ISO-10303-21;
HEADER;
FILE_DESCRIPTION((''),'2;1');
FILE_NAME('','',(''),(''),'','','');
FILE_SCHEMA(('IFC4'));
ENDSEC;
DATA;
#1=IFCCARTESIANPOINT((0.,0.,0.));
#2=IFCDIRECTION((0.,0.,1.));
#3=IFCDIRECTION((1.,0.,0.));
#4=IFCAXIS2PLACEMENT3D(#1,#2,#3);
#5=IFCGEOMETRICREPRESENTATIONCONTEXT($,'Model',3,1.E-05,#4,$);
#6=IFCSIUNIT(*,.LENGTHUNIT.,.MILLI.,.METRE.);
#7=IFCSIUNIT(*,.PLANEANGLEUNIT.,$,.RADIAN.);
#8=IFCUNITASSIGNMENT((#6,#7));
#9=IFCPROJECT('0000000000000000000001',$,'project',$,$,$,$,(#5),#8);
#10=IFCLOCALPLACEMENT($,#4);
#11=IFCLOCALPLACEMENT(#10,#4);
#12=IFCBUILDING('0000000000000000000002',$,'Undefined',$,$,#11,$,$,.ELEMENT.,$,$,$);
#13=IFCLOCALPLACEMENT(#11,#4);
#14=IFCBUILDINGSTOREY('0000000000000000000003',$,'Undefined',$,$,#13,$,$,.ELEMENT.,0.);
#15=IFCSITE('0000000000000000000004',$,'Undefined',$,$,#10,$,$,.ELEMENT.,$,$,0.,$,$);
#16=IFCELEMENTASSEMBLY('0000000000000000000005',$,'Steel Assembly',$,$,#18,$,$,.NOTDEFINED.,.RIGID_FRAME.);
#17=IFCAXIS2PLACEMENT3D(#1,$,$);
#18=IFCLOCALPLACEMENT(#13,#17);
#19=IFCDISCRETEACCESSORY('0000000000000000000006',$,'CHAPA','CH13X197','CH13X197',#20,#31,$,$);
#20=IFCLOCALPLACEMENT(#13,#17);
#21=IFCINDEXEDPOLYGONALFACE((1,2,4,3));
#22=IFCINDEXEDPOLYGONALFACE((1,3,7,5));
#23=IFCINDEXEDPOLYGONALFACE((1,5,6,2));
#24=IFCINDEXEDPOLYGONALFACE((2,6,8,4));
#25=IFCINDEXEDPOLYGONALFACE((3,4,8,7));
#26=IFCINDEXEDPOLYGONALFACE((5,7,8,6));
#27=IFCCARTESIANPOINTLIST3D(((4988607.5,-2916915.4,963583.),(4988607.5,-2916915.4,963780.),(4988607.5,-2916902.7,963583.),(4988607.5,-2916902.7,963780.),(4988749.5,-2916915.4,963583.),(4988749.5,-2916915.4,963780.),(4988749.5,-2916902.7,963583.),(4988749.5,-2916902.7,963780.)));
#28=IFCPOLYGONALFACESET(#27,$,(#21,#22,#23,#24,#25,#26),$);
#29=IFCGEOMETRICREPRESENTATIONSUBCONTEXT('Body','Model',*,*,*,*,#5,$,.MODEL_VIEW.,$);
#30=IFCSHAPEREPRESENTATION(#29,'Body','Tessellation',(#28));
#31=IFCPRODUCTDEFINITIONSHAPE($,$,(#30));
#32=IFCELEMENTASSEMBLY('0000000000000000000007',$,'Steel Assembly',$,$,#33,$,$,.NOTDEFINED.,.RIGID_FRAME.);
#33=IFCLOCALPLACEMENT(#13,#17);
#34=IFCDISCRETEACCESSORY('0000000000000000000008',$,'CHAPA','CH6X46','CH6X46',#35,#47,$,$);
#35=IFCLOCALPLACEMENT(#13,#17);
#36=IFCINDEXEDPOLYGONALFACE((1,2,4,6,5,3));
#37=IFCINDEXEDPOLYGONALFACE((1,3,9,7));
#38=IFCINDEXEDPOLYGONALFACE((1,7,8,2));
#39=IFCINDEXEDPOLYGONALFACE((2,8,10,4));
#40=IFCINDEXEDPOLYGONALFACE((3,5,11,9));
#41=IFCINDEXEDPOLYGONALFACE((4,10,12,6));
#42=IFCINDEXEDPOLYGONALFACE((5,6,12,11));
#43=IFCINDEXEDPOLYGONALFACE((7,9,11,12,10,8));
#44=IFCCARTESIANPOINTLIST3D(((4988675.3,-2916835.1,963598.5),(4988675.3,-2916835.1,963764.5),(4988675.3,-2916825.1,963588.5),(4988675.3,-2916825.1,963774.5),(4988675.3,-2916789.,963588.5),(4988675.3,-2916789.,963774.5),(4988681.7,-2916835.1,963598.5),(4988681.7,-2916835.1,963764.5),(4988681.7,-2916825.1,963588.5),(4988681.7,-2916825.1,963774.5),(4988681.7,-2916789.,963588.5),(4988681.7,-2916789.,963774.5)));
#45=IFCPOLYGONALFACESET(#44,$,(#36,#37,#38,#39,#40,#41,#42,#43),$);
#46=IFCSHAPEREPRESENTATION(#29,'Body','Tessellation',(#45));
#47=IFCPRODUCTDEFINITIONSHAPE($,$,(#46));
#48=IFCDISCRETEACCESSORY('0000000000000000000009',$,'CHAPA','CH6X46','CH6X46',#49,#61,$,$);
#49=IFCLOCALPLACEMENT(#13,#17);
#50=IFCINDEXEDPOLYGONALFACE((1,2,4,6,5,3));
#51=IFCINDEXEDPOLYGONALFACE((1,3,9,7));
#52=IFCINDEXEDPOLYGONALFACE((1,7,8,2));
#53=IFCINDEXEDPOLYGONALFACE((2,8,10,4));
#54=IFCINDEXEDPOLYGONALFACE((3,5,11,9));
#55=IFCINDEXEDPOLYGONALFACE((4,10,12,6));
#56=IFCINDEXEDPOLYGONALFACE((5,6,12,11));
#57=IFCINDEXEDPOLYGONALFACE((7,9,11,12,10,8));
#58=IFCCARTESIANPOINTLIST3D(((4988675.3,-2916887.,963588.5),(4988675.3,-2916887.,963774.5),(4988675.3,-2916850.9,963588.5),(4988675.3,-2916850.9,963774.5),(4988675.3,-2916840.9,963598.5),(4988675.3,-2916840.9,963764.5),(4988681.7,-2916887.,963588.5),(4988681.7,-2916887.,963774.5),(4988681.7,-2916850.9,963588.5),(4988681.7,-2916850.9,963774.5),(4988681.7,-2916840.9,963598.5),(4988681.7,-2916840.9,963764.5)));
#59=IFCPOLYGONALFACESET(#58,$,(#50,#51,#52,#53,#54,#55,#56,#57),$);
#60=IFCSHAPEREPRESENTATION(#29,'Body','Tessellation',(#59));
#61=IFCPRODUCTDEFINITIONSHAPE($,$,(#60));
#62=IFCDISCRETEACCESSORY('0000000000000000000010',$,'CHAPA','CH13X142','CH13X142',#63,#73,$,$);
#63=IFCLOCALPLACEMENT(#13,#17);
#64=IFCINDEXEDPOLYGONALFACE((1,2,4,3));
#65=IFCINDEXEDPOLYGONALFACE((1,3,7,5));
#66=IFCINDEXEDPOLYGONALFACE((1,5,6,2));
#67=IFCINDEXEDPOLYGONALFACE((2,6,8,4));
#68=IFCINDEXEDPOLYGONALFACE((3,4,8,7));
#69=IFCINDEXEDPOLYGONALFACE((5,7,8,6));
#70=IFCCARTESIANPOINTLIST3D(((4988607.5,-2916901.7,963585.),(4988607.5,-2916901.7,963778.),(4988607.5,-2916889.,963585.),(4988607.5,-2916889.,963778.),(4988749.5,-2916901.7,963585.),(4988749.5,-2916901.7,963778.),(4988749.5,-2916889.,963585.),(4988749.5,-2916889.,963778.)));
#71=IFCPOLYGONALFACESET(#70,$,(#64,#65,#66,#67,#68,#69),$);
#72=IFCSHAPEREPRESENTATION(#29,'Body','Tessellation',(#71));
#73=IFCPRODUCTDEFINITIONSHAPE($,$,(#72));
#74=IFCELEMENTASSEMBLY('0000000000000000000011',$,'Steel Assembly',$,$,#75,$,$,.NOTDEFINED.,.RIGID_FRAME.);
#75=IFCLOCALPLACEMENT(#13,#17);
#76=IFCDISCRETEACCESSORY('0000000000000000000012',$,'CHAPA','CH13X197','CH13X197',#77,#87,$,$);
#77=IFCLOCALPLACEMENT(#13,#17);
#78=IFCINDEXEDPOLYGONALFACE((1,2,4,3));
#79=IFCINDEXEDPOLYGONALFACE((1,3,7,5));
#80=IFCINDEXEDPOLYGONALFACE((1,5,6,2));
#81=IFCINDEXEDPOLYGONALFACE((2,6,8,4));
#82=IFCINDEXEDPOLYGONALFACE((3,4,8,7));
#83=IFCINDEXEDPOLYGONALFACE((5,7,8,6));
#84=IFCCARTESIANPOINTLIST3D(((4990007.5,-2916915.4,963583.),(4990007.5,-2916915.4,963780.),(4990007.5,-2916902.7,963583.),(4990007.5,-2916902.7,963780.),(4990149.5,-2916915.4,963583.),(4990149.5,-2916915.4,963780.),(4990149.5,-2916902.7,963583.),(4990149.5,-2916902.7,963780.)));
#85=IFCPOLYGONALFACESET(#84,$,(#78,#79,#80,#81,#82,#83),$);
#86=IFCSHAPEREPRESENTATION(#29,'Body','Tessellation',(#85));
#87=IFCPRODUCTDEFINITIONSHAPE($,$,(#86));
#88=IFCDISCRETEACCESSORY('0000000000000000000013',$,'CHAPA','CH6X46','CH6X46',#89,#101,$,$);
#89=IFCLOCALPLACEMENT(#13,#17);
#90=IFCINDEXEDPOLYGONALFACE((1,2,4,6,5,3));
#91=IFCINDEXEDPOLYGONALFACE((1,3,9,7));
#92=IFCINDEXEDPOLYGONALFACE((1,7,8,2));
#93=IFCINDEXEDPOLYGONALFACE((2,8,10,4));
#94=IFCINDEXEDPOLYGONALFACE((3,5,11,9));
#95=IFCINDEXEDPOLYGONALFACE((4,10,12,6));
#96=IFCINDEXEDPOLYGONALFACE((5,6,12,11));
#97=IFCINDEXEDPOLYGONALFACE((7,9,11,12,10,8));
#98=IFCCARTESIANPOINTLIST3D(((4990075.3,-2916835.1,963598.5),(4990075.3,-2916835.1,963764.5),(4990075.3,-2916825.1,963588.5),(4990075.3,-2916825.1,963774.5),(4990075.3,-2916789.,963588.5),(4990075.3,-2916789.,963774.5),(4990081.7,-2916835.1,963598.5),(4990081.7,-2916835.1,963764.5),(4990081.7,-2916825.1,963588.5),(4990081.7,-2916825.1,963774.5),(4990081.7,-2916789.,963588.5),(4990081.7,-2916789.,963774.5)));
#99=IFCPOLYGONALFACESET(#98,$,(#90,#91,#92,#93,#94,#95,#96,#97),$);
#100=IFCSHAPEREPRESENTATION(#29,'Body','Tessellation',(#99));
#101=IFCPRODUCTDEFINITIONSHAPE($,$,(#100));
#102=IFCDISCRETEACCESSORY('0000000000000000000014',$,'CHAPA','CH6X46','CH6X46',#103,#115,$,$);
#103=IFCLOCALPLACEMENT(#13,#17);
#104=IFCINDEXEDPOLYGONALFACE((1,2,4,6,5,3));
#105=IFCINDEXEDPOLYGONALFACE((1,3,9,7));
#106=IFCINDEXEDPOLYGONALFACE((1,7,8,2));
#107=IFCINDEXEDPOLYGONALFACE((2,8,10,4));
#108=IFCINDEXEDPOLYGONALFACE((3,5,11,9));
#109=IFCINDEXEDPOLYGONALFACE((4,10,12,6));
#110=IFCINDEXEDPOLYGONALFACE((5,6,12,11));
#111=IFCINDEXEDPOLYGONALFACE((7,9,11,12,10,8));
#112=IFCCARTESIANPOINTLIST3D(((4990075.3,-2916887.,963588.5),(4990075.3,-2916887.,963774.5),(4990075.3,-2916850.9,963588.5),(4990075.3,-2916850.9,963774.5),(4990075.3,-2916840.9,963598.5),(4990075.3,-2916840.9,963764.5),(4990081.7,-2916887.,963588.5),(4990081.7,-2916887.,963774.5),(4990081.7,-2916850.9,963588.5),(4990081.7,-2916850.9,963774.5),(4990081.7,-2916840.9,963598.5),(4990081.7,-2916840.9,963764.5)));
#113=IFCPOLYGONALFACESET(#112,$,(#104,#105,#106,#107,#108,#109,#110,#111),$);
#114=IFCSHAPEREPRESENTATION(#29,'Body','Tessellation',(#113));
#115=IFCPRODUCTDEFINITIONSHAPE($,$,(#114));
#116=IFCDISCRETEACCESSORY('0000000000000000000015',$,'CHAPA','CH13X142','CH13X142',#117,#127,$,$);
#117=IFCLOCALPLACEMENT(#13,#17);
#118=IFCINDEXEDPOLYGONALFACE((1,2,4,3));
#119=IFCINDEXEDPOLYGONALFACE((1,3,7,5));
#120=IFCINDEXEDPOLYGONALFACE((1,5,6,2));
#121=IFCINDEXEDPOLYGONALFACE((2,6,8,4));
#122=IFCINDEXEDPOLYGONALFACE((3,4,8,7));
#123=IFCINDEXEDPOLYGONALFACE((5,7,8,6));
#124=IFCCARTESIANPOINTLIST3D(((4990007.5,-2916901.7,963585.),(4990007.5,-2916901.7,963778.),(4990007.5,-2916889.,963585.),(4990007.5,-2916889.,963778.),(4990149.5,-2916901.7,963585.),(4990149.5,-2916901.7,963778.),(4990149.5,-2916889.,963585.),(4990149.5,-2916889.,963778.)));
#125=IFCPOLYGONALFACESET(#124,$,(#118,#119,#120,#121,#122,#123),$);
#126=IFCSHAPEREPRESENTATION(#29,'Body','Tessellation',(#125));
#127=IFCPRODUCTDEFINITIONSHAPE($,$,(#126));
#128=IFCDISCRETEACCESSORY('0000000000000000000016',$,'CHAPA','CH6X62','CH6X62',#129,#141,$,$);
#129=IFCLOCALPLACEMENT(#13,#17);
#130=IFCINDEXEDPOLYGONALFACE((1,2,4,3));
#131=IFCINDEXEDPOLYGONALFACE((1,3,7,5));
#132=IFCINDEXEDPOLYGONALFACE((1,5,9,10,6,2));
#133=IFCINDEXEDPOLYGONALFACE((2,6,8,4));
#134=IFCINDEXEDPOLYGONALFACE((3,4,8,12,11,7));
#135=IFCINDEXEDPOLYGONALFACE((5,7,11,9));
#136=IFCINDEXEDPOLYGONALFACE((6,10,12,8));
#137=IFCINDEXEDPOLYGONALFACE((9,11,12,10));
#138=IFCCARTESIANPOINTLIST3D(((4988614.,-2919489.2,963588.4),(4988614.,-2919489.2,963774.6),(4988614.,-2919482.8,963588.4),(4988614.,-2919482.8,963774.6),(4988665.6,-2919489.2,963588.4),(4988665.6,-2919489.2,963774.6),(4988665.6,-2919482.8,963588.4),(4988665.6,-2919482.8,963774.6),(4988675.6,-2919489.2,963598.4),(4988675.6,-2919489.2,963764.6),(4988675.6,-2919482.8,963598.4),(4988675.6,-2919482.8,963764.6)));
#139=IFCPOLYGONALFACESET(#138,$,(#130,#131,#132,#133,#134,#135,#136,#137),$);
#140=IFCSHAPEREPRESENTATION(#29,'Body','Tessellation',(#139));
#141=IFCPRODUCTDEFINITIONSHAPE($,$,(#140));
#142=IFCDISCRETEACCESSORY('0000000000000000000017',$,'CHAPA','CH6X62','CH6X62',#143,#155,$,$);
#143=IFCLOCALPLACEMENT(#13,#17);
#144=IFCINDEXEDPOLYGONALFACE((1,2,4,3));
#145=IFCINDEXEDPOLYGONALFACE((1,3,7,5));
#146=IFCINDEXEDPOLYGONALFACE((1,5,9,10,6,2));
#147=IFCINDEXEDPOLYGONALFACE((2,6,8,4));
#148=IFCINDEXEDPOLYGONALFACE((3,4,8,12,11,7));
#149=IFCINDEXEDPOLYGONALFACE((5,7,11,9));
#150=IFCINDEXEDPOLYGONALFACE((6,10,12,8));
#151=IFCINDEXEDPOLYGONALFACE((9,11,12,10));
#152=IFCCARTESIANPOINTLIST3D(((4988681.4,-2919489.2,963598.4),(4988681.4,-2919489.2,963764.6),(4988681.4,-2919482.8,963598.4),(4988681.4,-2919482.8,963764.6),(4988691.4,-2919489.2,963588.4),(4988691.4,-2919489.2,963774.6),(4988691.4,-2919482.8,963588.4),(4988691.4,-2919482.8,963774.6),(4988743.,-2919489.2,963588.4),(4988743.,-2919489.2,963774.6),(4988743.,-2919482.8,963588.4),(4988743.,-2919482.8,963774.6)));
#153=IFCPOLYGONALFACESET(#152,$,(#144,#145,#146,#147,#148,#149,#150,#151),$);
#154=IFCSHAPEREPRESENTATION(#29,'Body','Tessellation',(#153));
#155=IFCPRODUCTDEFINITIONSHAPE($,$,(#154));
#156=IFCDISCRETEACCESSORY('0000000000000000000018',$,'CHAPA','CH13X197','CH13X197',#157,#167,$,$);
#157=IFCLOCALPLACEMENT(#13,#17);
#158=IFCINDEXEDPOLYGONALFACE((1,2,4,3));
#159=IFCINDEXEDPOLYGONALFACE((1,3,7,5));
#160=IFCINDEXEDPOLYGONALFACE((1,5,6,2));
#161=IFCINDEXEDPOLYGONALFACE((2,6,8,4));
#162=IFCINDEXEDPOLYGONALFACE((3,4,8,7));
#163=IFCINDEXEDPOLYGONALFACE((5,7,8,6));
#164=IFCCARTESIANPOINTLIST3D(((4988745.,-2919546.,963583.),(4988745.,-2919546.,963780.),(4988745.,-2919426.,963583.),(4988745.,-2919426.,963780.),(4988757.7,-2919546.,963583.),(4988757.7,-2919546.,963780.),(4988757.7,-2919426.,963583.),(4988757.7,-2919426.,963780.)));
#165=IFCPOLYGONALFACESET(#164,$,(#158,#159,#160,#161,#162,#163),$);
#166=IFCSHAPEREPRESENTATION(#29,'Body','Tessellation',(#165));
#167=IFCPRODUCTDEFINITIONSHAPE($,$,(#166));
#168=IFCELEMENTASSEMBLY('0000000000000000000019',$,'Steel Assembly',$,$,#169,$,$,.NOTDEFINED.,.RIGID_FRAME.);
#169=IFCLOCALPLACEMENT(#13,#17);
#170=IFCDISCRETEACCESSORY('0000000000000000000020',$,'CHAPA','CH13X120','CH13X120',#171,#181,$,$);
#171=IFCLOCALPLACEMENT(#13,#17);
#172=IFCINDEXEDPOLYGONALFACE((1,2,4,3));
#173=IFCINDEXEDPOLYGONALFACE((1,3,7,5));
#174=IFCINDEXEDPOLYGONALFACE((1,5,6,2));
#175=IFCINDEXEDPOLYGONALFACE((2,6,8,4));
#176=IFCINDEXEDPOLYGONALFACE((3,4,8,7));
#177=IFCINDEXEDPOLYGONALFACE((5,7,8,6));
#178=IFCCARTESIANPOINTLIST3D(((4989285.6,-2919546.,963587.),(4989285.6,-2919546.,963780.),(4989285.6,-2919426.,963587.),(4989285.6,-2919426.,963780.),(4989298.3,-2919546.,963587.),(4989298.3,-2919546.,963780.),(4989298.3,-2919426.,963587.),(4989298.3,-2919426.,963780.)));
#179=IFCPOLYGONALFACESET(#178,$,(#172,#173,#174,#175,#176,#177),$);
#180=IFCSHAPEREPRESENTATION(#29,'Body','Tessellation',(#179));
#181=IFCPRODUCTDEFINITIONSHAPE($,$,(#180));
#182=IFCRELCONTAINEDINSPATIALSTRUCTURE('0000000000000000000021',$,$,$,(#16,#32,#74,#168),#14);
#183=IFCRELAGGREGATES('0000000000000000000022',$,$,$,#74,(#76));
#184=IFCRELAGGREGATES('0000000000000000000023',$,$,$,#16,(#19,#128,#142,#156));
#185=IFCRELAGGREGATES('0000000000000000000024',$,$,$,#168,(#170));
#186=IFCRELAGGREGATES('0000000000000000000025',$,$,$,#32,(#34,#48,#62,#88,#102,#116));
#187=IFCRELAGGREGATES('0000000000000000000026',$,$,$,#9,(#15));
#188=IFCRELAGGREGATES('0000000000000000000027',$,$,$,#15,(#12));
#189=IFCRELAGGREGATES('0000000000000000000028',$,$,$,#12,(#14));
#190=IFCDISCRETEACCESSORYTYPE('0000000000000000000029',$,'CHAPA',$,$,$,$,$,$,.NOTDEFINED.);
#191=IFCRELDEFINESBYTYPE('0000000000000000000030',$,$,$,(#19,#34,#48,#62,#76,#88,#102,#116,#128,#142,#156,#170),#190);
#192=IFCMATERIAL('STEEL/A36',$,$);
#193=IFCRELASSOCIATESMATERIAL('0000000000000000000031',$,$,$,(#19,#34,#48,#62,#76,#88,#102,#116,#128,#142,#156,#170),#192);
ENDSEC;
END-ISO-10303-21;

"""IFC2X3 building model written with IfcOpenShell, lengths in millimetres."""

from ifc_helpers import new_model, si_unit, frame, origin_with_axes, place, context, subcontext, project, spatial, polyline, outline, extrude, material, type_object, element, aggregate, save


model = new_model("IFC2X3")

# Units and contexts
model_context = context("Model", 3, precision=1e-05, world=origin_with_axes())
body_context = subcontext(model_context, "Body", "Model", "MODEL_VIEW")
ifc_project = project(units=[si_unit("LENGTHUNIT", "METRE", prefix="MILLI"), si_unit("PLANEANGLEUNIT", "RADIAN")], contexts=[model_context])

# Site, building, storey
site_placement = place(None, origin_with_axes())
site = spatial("IfcSite", under=ifc_project, at=site_placement, Name="Undefined", CompositionType="ELEMENT", RefElevation=0.0)
building_placement = place(site_placement, origin_with_axes())
building = spatial("IfcBuilding", under=site, at=building_placement, Name="Undefined", CompositionType="ELEMENT")
storey_placement = place(building_placement, origin_with_axes())
storey = spatial("IfcBuildingStorey", under=building, at=storey_placement, Name="Undefined", CompositionType="ELEMENT", Elevation=0.0)

# Element assembly, discrete accessory
assembly_1_placement = place(storey_placement, origin_with_axes())
assembly_1 = element("IfcElementAssembly", 1, at=assembly_1_placement, inside=storey, Name="Steel Assembly", AssemblyPlace="NOTDEFINED", PredefinedType="RIGID_FRAME")
ifc_material_1 = material(Name="STEEL/A36")
discrete_accessory_type_1 = type_object("IfcDiscreteAccessoryType", Name="CHAPA")
discrete_accessory_1_placement = place(assembly_1_placement, frame((4988678.5, -2916909.1, 963780.0), z_axis=(0.0, -1.0, 0.0), x_axis=(0.0, 0.0, -1.0)))
discrete_accessory_1 = element("IfcDiscreteAccessory", 2, at=discrete_accessory_1_placement, type_object=discrete_accessory_type_1, material=ifc_material_1, Name="CHAPA", Description="CH13X197", ObjectType="CH13X197", context=body_context, shape_type="SweptSolid", body=[
    extrude(outline(polyline([(197.0, -71.0), (0.0, -71.0), (0.0, 71.0), (197.0, 71.0), (197.0, -71.0)])), frame((0.0, 0.0, -6.3), z_axis=(0.0, 0.0, 1.0), x_axis=(1.0, 0.0, 0.0)), (0.0, 0.0, 1.0), 12.7),
])

# Element assembly, discrete accessories
assembly_2_placement = place(storey_placement, origin_with_axes())
assembly_2 = element("IfcElementAssembly", 3, at=assembly_2_placement, inside=storey, Name="Steel Assembly", AssemblyPlace="NOTDEFINED", PredefinedType="RIGID_FRAME")
discrete_accessory_2_placement = place(assembly_2_placement, frame((4988678.5, -2916835.1, 963774.5), z_axis=(-1.0, 0.0, 0.0), x_axis=(0.0, 1.0, 0.0)))
discrete_accessory_2 = element("IfcDiscreteAccessory", 4, at=discrete_accessory_2_placement, type_object=discrete_accessory_type_1, material=ifc_material_1, Name="CHAPA", Description="CH6X46", ObjectType="CH6X46", context=body_context, shape_type="SweptSolid", body=[
    extrude(outline(polyline([(0.0, 10.0), (10.0, 0.0), (46.1, 0.0), (46.1, 186.0), (10.0, 186.0), (0.0, 176.0), (0.0, 10.0)])), frame((0.0, 0.0, -3.2), z_axis=(0.0, 0.0, 1.0), x_axis=(1.0, 0.0, 0.0)), (0.0, 0.0, 1.0), 6.4),
])
discrete_accessory_3_placement = place(assembly_2_placement, frame((4988678.5, -2916840.9, 963774.5), z_axis=(1.0, 0.0, 0.0), x_axis=(0.0, -1.0, 0.0)))
discrete_accessory_3 = element("IfcDiscreteAccessory", 5, at=discrete_accessory_3_placement, type_object=discrete_accessory_type_1, material=ifc_material_1, Name="CHAPA", Description="CH6X46", ObjectType="CH6X46", context=body_context, shape_type="SweptSolid", body=[
    extrude(outline(polyline([(0.0, 10.0), (10.0, 0.0), (46.1, 0.0), (46.1, 186.0), (10.0, 186.0), (0.0, 176.0), (0.0, 10.0)])), frame((0.0, 0.0, -3.2), z_axis=(0.0, 0.0, 1.0), x_axis=(1.0, 0.0, 0.0)), (0.0, 0.0, 1.0), 6.4),
])
discrete_accessory_4_placement = place(assembly_2_placement, frame((4988678.5, -2916895.4, 963778.0), z_axis=(0.0, -1.0, 0.0), x_axis=(0.0, 0.0, -1.0)))
discrete_accessory_4 = element("IfcDiscreteAccessory", 6, at=discrete_accessory_4_placement, type_object=discrete_accessory_type_1, material=ifc_material_1, Name="CHAPA", Description="CH13X142", ObjectType="CH13X142", context=body_context, shape_type="SweptSolid", body=[
    extrude(outline(polyline([(193.0, -71.0), (0.0, -71.0), (0.0, 71.0), (193.0, 71.0), (193.0, -71.0)])), frame((0.0, 0.0, -6.3), z_axis=(0.0, 0.0, 1.0), x_axis=(1.0, 0.0, 0.0)), (0.0, 0.0, 1.0), 12.7),
])

# Element assembly, discrete accessory
assembly_3_placement = place(storey_placement, origin_with_axes())
assembly_3 = element("IfcElementAssembly", 7, at=assembly_3_placement, inside=storey, Name="Steel Assembly", AssemblyPlace="NOTDEFINED", PredefinedType="RIGID_FRAME")
discrete_accessory_5_placement = place(assembly_3_placement, frame((4990078.5, -2916909.1, 963780.0), z_axis=(0.0, -1.0, 0.0), x_axis=(0.0, 0.0, -1.0)))
discrete_accessory_5 = element("IfcDiscreteAccessory", 8, at=discrete_accessory_5_placement, type_object=discrete_accessory_type_1, material=ifc_material_1, Name="CHAPA", Description="CH13X197", ObjectType="CH13X197", context=body_context, shape_type="SweptSolid", body=[
    extrude(outline(polyline([(197.0, -71.0), (0.0, -71.0), (0.0, 71.0), (197.0, 71.0), (197.0, -71.0)])), frame((0.0, 0.0, -6.3), z_axis=(0.0, 0.0, 1.0), x_axis=(1.0, 0.0, 0.0)), (0.0, 0.0, 1.0), 12.7),
])
aggregate(assembly_3, [discrete_accessory_5])

# Discrete accessories
discrete_accessory_6_placement = place(assembly_2_placement, frame((4990078.5, -2916835.1, 963774.5), z_axis=(-1.0, 0.0, 0.0), x_axis=(0.0, 1.0, 0.0)))
discrete_accessory_6 = element("IfcDiscreteAccessory", 9, at=discrete_accessory_6_placement, type_object=discrete_accessory_type_1, material=ifc_material_1, Name="CHAPA", Description="CH6X46", ObjectType="CH6X46", context=body_context, shape_type="SweptSolid", body=[
    extrude(outline(polyline([(0.0, 10.0), (10.0, 0.0), (46.1, 0.0), (46.1, 186.0), (10.0, 186.0), (0.0, 176.0), (0.0, 10.0)])), frame((0.0, 0.0, -3.2), z_axis=(0.0, 0.0, 1.0), x_axis=(1.0, 0.0, 0.0)), (0.0, 0.0, 1.0), 6.4),
])
discrete_accessory_7_placement = place(assembly_2_placement, frame((4990078.5, -2916840.9, 963774.5), z_axis=(1.0, 0.0, 0.0), x_axis=(0.0, -1.0, 0.0)))
discrete_accessory_7 = element("IfcDiscreteAccessory", 10, at=discrete_accessory_7_placement, type_object=discrete_accessory_type_1, material=ifc_material_1, Name="CHAPA", Description="CH6X46", ObjectType="CH6X46", context=body_context, shape_type="SweptSolid", body=[
    extrude(outline(polyline([(0.0, 10.0), (10.0, 0.0), (46.1, 0.0), (46.1, 186.0), (10.0, 186.0), (0.0, 176.0), (0.0, 10.0)])), frame((0.0, 0.0, -3.2), z_axis=(0.0, 0.0, 1.0), x_axis=(1.0, 0.0, 0.0)), (0.0, 0.0, 1.0), 6.4),
])
discrete_accessory_8_placement = place(assembly_2_placement, frame((4990078.5, -2916895.4, 963778.0), z_axis=(0.0, -1.0, 0.0), x_axis=(0.0, 0.0, -1.0)))
discrete_accessory_8 = element("IfcDiscreteAccessory", 11, at=discrete_accessory_8_placement, type_object=discrete_accessory_type_1, material=ifc_material_1, Name="CHAPA", Description="CH13X142", ObjectType="CH13X142", context=body_context, shape_type="SweptSolid", body=[
    extrude(outline(polyline([(193.0, -71.0), (0.0, -71.0), (0.0, 71.0), (193.0, 71.0), (193.0, -71.0)])), frame((0.0, 0.0, -6.3), z_axis=(0.0, 0.0, 1.0), x_axis=(1.0, 0.0, 0.0)), (0.0, 0.0, 1.0), 12.7),
])
discrete_accessory_9_placement = place(assembly_1_placement, frame((4988675.6, -2919486.0, 963774.6), z_axis=(0.0, -1.0, 0.0), x_axis=(-1.0, 0.0, 0.0)))
discrete_accessory_9 = element("IfcDiscreteAccessory", 12, at=discrete_accessory_9_placement, type_object=discrete_accessory_type_1, material=ifc_material_1, Name="CHAPA", Description="CH6X62", ObjectType="CH6X62", context=body_context, shape_type="SweptSolid", body=[
    extrude(outline(polyline([(0.0, 10.0), (10.0, 0.0), (61.6, 0.0), (61.6, 186.2), (10.0, 186.2), (0.0, 176.2), (0.0, 10.0)])), frame((0.0, 0.0, -3.2), z_axis=(0.0, 0.0, 1.0), x_axis=(1.0, 0.0, 0.0)), (0.0, 0.0, 1.0), 6.4),
])
discrete_accessory_10_placement = place(assembly_1_placement, frame((4988681.4, -2919486.0, 963774.6), z_axis=(0.0, 1.0, 0.0), x_axis=(1.0, 0.0, 0.0)))
discrete_accessory_10 = element("IfcDiscreteAccessory", 13, at=discrete_accessory_10_placement, type_object=discrete_accessory_type_1, material=ifc_material_1, Name="CHAPA", Description="CH6X62", ObjectType="CH6X62", context=body_context, shape_type="SweptSolid", body=[
    extrude(outline(polyline([(0.0, 10.0), (10.0, 0.0), (61.6, 0.0), (61.6, 186.2), (10.0, 186.2), (0.0, 176.2), (0.0, 10.0)])), frame((0.0, 0.0, -3.2), z_axis=(0.0, 0.0, 1.0), x_axis=(1.0, 0.0, 0.0)), (0.0, 0.0, 1.0), 6.4),
])
discrete_accessory_11_placement = place(assembly_1_placement, frame((4988751.3, -2919486.0, 963780.0), z_axis=(1.0, 0.0, 0.0), x_axis=(0.0, 0.0, -1.0)))
discrete_accessory_11 = element("IfcDiscreteAccessory", 14, at=discrete_accessory_11_placement, type_object=discrete_accessory_type_1, material=ifc_material_1, Name="CHAPA", Description="CH13X197", ObjectType="CH13X197", context=body_context, shape_type="SweptSolid", body=[
    extrude(outline(polyline([(197.0, -60.0), (0.0, -60.0), (0.0, 60.0), (197.0, 60.0), (197.0, -60.0)])), frame((0.0, 0.0, -6.3), z_axis=(0.0, 0.0, 1.0), x_axis=(1.0, 0.0, 0.0)), (0.0, 0.0, 1.0), 12.7),
])
aggregate(assembly_1, [discrete_accessory_1, discrete_accessory_9, discrete_accessory_10, discrete_accessory_11])

# Element assembly, discrete accessory
assembly_4_placement = place(storey_placement, origin_with_axes())
assembly_4 = element("IfcElementAssembly", 15, at=assembly_4_placement, inside=storey, Name="Steel Assembly", AssemblyPlace="NOTDEFINED", PredefinedType="RIGID_FRAME")
discrete_accessory_12_placement = place(assembly_4_placement, frame((4989291.9, -2919486.0, 963780.0), z_axis=(-1.0, 0.0, 0.0), x_axis=(0.0, 0.0, -1.0)))
discrete_accessory_12 = element("IfcDiscreteAccessory", 16, at=discrete_accessory_12_placement, type_object=discrete_accessory_type_1, material=ifc_material_1, Name="CHAPA", Description="CH13X120", ObjectType="CH13X120", context=body_context, shape_type="SweptSolid", body=[
    extrude(outline(polyline([(193.0, 60.0), (193.0, -60.0), (0.0, -60.0), (0.0, 60.0), (193.0, 60.0)])), frame((0.0, 0.0, -6.3), z_axis=(0.0, 0.0, 1.0), x_axis=(1.0, 0.0, 0.0)), (0.0, 0.0, 1.0), 12.7),
])
aggregate(assembly_4, [discrete_accessory_12])

aggregate(assembly_2, [discrete_accessory_2, discrete_accessory_3, discrete_accessory_4, discrete_accessory_6, discrete_accessory_7, discrete_accessory_8])

save(model, "model.ifc")
